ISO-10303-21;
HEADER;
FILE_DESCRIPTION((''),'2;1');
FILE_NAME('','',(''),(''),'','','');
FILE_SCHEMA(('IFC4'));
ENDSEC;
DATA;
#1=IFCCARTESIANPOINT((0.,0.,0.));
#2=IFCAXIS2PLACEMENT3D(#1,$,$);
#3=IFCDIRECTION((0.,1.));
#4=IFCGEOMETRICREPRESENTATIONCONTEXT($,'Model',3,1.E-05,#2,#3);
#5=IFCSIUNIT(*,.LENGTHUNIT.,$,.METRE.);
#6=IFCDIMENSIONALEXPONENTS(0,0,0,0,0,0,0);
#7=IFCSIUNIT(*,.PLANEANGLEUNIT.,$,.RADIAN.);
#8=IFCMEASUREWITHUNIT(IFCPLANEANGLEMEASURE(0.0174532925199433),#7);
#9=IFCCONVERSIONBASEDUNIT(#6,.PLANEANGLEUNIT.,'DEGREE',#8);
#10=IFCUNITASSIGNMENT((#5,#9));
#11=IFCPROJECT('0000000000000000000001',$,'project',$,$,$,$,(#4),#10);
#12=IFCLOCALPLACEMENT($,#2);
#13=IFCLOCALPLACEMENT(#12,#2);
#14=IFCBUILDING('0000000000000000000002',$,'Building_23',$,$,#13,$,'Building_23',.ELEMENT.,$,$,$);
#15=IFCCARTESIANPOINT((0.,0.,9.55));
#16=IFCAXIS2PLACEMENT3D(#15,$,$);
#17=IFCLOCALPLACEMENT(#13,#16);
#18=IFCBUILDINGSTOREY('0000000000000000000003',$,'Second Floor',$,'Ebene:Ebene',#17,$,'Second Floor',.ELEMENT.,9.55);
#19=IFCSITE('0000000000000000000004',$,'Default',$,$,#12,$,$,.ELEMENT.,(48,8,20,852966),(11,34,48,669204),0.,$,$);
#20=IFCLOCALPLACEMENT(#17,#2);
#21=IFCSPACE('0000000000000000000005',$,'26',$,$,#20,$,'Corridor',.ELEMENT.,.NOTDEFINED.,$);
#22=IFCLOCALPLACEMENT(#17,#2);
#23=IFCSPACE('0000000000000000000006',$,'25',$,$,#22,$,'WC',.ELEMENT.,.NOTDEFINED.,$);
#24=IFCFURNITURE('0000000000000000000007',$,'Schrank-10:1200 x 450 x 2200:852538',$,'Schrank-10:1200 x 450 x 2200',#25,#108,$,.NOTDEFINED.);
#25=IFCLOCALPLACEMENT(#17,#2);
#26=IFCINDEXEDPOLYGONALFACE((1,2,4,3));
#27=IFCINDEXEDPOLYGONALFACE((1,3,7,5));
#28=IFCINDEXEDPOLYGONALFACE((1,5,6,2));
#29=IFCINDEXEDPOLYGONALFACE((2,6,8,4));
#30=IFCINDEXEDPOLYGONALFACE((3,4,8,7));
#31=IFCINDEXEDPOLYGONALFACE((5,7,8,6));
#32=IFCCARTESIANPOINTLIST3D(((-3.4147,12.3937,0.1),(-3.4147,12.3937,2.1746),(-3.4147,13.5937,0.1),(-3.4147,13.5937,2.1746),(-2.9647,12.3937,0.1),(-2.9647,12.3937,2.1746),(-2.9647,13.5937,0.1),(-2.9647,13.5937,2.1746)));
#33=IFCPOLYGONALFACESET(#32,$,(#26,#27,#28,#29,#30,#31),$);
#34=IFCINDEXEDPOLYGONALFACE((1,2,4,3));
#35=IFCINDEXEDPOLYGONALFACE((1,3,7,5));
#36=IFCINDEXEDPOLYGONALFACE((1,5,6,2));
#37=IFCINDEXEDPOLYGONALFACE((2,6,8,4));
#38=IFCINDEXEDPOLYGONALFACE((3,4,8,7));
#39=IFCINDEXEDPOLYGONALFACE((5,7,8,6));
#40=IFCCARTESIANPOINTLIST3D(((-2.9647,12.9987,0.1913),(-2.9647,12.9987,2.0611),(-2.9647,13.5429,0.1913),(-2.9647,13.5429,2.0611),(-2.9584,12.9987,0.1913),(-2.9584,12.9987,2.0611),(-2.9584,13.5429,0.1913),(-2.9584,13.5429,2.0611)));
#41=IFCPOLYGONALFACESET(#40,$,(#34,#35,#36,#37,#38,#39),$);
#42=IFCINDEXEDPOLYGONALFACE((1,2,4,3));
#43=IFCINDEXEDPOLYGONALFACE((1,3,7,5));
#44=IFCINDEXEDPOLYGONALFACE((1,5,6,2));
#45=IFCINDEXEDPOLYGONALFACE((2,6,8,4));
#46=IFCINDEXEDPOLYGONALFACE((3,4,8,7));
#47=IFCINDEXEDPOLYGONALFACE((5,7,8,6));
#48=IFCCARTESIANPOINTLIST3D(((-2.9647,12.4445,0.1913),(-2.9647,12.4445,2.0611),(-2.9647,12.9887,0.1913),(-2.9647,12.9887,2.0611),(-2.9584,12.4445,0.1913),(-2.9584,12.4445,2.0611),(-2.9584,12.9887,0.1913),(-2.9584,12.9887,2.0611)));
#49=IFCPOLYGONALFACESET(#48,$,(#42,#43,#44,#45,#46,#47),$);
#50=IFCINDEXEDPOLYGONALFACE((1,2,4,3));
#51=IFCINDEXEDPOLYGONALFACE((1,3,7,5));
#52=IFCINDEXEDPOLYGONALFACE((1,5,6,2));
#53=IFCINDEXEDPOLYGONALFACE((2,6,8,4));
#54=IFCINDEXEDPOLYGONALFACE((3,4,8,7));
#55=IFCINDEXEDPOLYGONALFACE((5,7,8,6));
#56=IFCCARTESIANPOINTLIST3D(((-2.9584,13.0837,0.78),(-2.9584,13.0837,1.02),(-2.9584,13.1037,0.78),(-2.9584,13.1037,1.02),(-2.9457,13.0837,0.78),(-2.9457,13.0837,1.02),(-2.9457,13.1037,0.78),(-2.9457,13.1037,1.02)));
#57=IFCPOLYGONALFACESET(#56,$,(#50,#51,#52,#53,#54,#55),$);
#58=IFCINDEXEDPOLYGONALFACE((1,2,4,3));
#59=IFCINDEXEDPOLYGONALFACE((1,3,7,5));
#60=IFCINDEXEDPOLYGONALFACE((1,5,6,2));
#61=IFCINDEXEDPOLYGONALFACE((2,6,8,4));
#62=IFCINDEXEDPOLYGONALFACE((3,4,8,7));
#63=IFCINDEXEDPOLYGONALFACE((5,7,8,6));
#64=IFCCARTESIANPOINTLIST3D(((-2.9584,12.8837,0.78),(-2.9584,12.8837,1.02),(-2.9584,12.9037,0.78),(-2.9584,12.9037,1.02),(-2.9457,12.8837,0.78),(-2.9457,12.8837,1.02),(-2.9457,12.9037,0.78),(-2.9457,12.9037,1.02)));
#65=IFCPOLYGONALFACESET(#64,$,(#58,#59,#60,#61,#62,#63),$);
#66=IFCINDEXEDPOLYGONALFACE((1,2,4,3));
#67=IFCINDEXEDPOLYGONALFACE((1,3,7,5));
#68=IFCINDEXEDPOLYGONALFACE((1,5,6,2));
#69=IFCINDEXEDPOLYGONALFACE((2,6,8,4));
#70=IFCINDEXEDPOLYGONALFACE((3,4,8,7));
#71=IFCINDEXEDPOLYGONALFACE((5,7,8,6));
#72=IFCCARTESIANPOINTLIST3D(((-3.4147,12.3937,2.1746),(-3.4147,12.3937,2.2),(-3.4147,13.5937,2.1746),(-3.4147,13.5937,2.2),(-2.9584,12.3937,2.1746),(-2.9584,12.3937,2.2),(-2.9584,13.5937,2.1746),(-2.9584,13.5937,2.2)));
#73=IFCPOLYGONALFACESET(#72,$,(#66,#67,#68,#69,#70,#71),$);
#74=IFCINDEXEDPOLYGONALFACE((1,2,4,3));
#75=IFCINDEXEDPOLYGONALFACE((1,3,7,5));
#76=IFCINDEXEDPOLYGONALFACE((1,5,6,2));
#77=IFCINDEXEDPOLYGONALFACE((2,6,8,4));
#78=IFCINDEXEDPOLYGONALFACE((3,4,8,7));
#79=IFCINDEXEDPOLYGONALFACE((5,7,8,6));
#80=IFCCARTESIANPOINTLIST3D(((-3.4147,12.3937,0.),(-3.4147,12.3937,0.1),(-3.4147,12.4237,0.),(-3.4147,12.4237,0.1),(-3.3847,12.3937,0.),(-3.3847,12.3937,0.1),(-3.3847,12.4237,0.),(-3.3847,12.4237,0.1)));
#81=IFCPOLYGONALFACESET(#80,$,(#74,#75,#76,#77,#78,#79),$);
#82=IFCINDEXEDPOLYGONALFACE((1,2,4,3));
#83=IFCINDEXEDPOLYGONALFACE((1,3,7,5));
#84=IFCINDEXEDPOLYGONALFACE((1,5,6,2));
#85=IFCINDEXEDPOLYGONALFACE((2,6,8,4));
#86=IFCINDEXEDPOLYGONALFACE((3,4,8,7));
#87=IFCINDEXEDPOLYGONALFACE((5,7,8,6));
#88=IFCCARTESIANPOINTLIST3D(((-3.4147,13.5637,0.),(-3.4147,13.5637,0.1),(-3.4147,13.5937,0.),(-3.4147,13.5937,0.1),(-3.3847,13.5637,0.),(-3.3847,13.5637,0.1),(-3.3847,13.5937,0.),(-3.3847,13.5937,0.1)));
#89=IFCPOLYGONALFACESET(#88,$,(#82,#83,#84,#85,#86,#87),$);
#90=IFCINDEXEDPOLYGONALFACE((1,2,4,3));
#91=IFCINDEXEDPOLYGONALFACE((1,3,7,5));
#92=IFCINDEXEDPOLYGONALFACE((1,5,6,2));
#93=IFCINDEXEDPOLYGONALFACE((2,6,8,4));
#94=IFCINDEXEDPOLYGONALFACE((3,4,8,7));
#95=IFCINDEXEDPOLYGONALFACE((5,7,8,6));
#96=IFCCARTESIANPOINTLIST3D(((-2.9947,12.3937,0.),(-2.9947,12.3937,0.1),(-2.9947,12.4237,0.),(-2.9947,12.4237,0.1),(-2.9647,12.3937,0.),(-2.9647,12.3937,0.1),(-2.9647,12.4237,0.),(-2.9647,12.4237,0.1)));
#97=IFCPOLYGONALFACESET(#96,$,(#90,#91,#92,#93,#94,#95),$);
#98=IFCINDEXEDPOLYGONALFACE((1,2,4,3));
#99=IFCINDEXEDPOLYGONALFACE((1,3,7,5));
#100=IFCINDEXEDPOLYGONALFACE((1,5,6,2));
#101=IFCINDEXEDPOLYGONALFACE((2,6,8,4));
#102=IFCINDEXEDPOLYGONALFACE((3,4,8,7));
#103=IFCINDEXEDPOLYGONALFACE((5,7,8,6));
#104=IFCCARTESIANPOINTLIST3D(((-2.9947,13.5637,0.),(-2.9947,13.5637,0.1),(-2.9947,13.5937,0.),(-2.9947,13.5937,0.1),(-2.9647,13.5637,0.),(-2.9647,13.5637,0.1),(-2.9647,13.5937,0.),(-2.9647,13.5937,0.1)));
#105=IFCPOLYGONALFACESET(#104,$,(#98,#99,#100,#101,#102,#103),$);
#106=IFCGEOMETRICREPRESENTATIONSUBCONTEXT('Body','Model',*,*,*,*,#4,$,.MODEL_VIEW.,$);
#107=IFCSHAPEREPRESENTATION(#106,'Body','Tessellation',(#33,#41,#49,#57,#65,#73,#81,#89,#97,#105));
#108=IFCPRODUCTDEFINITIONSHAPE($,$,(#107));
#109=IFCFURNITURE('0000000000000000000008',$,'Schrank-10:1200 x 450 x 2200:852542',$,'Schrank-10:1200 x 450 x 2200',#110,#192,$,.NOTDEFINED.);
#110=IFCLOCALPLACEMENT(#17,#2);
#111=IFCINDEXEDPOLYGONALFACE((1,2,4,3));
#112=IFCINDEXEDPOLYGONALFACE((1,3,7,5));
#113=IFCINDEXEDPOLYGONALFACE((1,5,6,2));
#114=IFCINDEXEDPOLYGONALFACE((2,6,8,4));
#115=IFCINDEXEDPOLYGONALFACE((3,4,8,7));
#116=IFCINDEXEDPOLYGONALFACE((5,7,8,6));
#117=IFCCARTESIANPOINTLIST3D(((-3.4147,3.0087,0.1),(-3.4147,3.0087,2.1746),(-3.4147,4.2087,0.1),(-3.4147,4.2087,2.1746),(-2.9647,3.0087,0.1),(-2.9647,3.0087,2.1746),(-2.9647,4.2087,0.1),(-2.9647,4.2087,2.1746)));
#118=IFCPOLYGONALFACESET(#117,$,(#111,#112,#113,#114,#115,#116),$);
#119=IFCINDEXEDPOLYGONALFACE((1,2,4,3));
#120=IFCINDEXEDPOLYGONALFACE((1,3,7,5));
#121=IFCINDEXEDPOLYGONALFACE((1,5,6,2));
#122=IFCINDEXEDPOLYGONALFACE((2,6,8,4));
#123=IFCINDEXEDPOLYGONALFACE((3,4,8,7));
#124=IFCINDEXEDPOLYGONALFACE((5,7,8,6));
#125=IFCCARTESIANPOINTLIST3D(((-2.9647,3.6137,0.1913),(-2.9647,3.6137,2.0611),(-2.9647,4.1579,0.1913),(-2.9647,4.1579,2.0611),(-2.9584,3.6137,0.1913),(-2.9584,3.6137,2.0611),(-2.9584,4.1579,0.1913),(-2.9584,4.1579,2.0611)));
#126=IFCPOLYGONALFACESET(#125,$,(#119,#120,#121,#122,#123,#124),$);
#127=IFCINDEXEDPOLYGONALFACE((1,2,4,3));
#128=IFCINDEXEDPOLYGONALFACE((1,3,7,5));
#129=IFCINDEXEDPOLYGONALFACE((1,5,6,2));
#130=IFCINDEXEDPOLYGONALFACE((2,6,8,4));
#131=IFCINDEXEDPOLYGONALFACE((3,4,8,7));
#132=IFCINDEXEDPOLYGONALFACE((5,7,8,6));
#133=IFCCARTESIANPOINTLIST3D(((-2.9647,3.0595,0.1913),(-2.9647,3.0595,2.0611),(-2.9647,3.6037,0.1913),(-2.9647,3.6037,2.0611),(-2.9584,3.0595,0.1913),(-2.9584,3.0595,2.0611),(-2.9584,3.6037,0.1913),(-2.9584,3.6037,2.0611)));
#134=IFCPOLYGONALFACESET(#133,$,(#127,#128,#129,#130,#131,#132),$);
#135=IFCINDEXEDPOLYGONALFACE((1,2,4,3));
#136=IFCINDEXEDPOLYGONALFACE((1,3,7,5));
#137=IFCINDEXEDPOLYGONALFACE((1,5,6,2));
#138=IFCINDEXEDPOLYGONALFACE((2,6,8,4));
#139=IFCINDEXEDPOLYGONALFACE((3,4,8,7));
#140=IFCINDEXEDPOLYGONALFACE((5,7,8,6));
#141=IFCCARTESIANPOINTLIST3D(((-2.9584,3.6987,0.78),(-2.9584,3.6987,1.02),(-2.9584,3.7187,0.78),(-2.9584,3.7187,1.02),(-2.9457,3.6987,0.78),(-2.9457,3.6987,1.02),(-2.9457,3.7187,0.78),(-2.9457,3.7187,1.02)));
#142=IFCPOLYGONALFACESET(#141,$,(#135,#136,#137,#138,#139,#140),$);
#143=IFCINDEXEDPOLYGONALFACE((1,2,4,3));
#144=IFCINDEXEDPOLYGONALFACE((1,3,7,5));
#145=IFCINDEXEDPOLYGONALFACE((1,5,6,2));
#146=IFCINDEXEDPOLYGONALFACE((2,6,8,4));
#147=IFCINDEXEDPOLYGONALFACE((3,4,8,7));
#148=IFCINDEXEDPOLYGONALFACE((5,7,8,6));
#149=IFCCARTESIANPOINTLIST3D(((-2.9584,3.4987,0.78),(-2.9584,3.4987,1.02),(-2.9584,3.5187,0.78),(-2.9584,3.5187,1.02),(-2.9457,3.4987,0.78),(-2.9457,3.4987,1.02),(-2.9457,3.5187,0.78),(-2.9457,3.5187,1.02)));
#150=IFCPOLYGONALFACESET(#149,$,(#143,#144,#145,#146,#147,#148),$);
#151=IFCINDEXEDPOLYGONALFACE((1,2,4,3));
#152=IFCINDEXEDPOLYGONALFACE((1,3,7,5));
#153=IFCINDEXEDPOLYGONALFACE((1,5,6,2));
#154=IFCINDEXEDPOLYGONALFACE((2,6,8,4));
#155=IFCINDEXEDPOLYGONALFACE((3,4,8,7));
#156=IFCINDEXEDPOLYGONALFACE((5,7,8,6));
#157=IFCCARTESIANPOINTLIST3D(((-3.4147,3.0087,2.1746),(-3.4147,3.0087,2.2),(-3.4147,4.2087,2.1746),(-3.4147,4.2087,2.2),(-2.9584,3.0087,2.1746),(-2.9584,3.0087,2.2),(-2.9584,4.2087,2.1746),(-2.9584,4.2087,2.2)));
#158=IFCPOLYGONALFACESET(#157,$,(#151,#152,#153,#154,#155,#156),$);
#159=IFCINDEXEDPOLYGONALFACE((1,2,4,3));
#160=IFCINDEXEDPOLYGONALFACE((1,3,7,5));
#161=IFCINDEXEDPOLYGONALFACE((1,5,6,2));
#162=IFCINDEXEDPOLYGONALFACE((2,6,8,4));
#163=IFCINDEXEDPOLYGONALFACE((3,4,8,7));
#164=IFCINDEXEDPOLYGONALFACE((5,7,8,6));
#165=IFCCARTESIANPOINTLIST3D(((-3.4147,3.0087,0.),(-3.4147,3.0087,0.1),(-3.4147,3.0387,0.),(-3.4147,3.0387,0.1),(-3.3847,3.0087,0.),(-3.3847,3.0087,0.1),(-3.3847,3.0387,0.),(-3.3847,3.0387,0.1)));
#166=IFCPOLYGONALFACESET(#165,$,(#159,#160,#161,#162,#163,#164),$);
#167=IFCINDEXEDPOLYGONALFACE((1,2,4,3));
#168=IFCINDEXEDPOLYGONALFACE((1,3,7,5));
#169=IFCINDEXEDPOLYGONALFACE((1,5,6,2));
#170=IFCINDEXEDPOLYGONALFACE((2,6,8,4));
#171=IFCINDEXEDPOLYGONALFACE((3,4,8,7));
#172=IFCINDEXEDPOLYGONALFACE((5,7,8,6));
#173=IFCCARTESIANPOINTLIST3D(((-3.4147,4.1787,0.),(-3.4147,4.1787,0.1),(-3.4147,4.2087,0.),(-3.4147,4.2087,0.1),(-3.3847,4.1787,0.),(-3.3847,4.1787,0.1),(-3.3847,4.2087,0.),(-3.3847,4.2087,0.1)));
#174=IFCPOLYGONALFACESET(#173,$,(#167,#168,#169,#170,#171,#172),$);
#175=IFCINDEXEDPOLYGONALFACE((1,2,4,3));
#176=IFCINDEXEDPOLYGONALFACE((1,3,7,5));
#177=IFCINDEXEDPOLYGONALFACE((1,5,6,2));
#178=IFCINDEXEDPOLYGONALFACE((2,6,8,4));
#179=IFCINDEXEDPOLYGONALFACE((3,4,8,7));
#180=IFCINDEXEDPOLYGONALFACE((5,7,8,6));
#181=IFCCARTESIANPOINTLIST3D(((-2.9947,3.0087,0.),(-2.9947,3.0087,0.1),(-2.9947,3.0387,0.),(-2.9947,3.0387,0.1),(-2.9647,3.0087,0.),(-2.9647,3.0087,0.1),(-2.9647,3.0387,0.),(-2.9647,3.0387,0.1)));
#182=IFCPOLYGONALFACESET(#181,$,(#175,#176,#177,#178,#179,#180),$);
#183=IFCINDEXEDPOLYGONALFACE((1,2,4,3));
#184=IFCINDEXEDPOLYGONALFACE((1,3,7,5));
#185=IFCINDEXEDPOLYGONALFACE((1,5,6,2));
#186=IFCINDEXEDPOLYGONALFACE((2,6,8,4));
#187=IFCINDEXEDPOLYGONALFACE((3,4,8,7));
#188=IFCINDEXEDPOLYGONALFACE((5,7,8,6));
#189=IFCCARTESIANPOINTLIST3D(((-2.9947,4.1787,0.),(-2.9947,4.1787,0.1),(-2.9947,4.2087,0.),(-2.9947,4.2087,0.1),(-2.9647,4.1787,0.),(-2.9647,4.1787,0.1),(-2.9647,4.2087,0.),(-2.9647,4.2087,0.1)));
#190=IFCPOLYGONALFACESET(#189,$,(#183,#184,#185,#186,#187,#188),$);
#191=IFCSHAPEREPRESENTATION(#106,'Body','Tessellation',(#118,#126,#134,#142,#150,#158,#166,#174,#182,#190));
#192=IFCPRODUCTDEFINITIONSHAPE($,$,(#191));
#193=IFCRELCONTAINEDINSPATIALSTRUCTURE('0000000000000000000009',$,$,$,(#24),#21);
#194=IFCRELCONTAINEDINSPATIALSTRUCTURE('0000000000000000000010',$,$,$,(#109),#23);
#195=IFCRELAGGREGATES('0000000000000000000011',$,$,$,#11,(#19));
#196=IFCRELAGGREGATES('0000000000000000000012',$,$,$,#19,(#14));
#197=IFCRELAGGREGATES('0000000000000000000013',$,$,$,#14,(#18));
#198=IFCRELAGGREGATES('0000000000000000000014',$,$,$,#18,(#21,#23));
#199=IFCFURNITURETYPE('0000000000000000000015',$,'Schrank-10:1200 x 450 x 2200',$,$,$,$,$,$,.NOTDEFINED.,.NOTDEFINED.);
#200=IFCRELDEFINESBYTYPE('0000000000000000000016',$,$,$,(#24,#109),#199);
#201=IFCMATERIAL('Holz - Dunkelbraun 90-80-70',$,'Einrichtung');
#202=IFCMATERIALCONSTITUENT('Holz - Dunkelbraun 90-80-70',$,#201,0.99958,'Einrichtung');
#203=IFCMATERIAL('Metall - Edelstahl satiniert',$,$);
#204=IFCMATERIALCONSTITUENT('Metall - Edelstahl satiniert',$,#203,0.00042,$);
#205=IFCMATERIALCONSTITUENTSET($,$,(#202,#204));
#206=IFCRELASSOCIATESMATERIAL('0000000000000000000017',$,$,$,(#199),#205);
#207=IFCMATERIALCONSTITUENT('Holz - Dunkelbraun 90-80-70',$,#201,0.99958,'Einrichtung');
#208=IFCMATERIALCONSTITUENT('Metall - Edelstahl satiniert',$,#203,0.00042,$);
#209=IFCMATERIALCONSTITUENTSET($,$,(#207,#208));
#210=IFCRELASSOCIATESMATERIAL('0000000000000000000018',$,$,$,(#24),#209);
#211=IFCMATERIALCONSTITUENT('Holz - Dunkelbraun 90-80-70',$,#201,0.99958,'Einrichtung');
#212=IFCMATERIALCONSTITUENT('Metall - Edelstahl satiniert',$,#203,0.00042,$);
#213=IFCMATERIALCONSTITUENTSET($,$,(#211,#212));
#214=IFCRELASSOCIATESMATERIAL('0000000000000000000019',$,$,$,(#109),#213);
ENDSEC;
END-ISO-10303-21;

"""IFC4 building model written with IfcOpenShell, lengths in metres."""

from ifc_helpers import new_model, entity, si_unit, converted_unit, direction, frame, origin, place, context, subcontext, project, spatial, indexed_curve, outline, extrude, source, transform, mapped, material, constituent, constituent_set, type_object, type_shapes, element, save


model = new_model("IFC4")

# Units and contexts
model_context = context("Model", 3, precision=1e-05, world=origin(), true_north=direction((0.0, 1.0)))
body_context = subcontext(model_context, "Body", "Model", "MODEL_VIEW")
ifc_project = project(units=[si_unit("LENGTHUNIT", "METRE"), converted_unit("PLANEANGLEUNIT", "DEGREE", entity("IfcPlaneAngleMeasure", 0.0174532925199433), si_unit("PLANEANGLEUNIT", "RADIAN"), dimensions=[0, 0, 0, 0, 0, 0, 0])], contexts=[model_context])

# Site, building, storey
site_placement = place(None, origin())
site = spatial("IfcSite", under=ifc_project, at=site_placement, Name="Default", CompositionType="ELEMENT", RefLatitude=(48, 8, 20, 852966), RefLongitude=(11, 34, 48, 669204), RefElevation=0.0)
building_placement = place(site_placement, origin())
building = spatial("IfcBuilding", under=site, at=building_placement, Name="Building_23", LongName="Building_23", CompositionType="ELEMENT")
storey_placement = place(building_placement, frame((0.0, 0.0, 9.55)))
storey = spatial("IfcBuildingStorey", under=building, at=storey_placement, Name="Second Floor", ObjectType="Ebene:Ebene", LongName="Second Floor", CompositionType="ELEMENT", Elevation=9.55)

# Shared definitions
ifc_material_1 = material(Name="Holz - Dunkelbraun 90-80-70", Category="Einrichtung")
ifc_material_2 = material(Name="Metall - Edelstahl satiniert")

# Shared definitions
space_1_placement = place(storey_placement, origin())
space_1 = spatial("IfcSpace", under=storey, at=space_1_placement, Name="26", LongName="Corridor", CompositionType="ELEMENT", PredefinedType="NOTDEFINED")

# Furniture
ifc_constituent_1 = constituent(ifc_material_1, Name="Holz - Dunkelbraun 90-80-70", Category="Einrichtung", fraction=0.99958)
ifc_constituent_2 = constituent(ifc_material_2, Name="Metall - Edelstahl satiniert", fraction=0.00042)
ifc_constituent_set_1 = constituent_set(constituents=[ifc_constituent_1, ifc_constituent_2])
ifc_constituent_3 = constituent(ifc_material_1, Name="Holz - Dunkelbraun 90-80-70", Category="Einrichtung", fraction=0.99958)
ifc_constituent_4 = constituent(ifc_material_2, Name="Metall - Edelstahl satiniert", fraction=0.00042)
ifc_constituent_set_2 = constituent_set(constituents=[ifc_constituent_3, ifc_constituent_4])
furniture_type_1 = type_object("IfcFurnitureType", Name="Schrank-10:1200 x 450 x 2200", AssemblyPlace="NOTDEFINED", PredefinedType="NOTDEFINED", material=ifc_constituent_set_2)
shared_shape_1 = source(origin(), body_context, "Body", "SweptSolid", [
    extrude(outline(indexed_curve([(-0.225, -0.6), (0.225, -0.6), (0.225, 0.6), (-0.225, 0.6), (-0.225, -0.6)], self_intersect=False)), frame((-0.2692, -0.3632, 0.1), z_axis=(0.0, 0.0, 1.0), x_axis=(0.0, 1.0, 0.0)), (0.0, 0.0, 1.0), 2.0746),
    extrude(outline(indexed_curve([(-0.0032, -0.2721), (0.0032, -0.2721), (0.0032, 0.2721), (-0.0032, 0.2721), (-0.0032, -0.2721)], self_intersect=False)), frame((0.0079, -0.5913, 0.1913), z_axis=(0.0, 0.0, 1.0), x_axis=(0.0, 1.0, 0.0)), (0.0, 0.0, 1.0), 1.8698),
    extrude(outline(indexed_curve([(-0.0032, -0.2721), (0.0032, -0.2721), (0.0032, 0.2721), (-0.0032, 0.2721), (-0.0032, -0.2721)], self_intersect=False)), frame((-0.5463, -0.5913, 0.1913), z_axis=(0.0, 0.0, 1.0), x_axis=(0.0, 1.0, 0.0)), (0.0, 0.0, 1.0), 1.8698),
    extrude(outline(indexed_curve([(-0.0063, -0.01), (0.0063, -0.01), (0.0063, 0.01), (-0.0063, 0.01), (-0.0063, -0.01)], self_intersect=False)), frame((-0.1692, -0.6009, 0.78), z_axis=(0.0, 0.0, 1.0), x_axis=(0.0, 1.0, 0.0)), (0.0, 0.0, 1.0), 0.24),
    extrude(outline(indexed_curve([(-0.0063, -0.01), (0.0063, -0.01), (0.0063, 0.01), (-0.0063, 0.01), (-0.0063, -0.01)], self_intersect=False)), frame((-0.3692, -0.6009, 0.78), z_axis=(0.0, 0.0, 1.0), x_axis=(0.0, 1.0, 0.0)), (0.0, 0.0, 1.0), 0.24),
    extrude(outline(indexed_curve([(-0.6, -0.2282), (0.6, -0.2282), (0.6, 0.2282), (-0.6, 0.2282), (-0.6, -0.2282)], self_intersect=False)), frame((-0.2692, -0.3663, 2.1746), z_axis=(0.0, 0.0, 1.0), x_axis=(-1.0, 0.0, 0.0)), (0.0, 0.0, 1.0), 0.0254),
    extrude(outline(indexed_curve([(-0.015, -0.015), (0.015, -0.015), (0.015, 0.015), (-0.015, 0.015), (-0.015, -0.015)], self_intersect=False)), frame((-0.8542, -0.1532, 0.0), z_axis=(0.0, 0.0, 1.0), x_axis=(-1.0, 0.0, 0.0)), (0.0, 0.0, 1.0), 0.1),
    extrude(outline(indexed_curve([(-0.015, -0.015), (0.015, -0.015), (0.015, 0.015), (-0.015, 0.015), (-0.015, -0.015)], self_intersect=False)), frame((0.3158, -0.1532, 0.0), z_axis=(0.0, 0.0, 1.0), x_axis=(0.0, -1.0, 0.0)), (0.0, 0.0, 1.0), 0.1),
    extrude(outline(indexed_curve([(-0.015, -0.015), (0.015, -0.015), (0.015, 0.015), (-0.015, 0.015), (-0.015, -0.015)], self_intersect=False)), frame((-0.8542, -0.5732, 0.0), z_axis=(0.0, 0.0, 1.0), x_axis=(0.0, 1.0, 0.0)), (0.0, 0.0, 1.0), 0.1),
    extrude(outline(indexed_curve([(-0.015, -0.015), (0.015, -0.015), (0.015, 0.015), (-0.015, 0.015), (-0.015, -0.015)], self_intersect=False)), frame((0.3158, -0.5732, 0.0)), (0.0, 0.0, 1.0), 0.1),
])
type_shapes(furniture_type_1, [shared_shape_1])
furniture_1_placement = place(space_1_placement, frame((-3.5529, 13.2629, 0.0), z_axis=(0.0, 0.0, 1.0), x_axis=(0.0, 1.0, 0.0)))
element("IfcFurniture", 1, at=furniture_1_placement, inside=space_1, type_object=furniture_type_1, material=ifc_constituent_set_1, Name="Schrank-10:1200 x 450 x 2200:852538", ObjectType="Schrank-10:1200 x 450 x 2200", PredefinedType="NOTDEFINED", context=body_context, shape_type="MappedRepresentation", body=[
    mapped(shared_shape_1, transform((0.0, 0.0, 0.0), scale=1.0)),
])

# Shared definitions
space_2_placement = place(storey_placement, origin())
space_2 = spatial("IfcSpace", under=storey, at=space_2_placement, Name="25", LongName="WC", CompositionType="ELEMENT", PredefinedType="NOTDEFINED")

# Furniture
ifc_constituent_5 = constituent(ifc_material_1, Name="Holz - Dunkelbraun 90-80-70", Category="Einrichtung", fraction=0.99958)
ifc_constituent_6 = constituent(ifc_material_2, Name="Metall - Edelstahl satiniert", fraction=0.00042)
ifc_constituent_set_3 = constituent_set(constituents=[ifc_constituent_5, ifc_constituent_6])
furniture_2_placement = place(space_2_placement, frame((-3.5529, 3.8779, 0.0), z_axis=(0.0, 0.0, 1.0), x_axis=(0.0, 1.0, 0.0)))
element("IfcFurniture", 2, at=furniture_2_placement, inside=space_2, type_object=furniture_type_1, material=ifc_constituent_set_3, Name="Schrank-10:1200 x 450 x 2200:852542", ObjectType="Schrank-10:1200 x 450 x 2200", PredefinedType="NOTDEFINED", context=body_context, shape_type="MappedRepresentation", body=[
    mapped(shared_shape_1, transform((0.0, 0.0, 0.0), scale=1.0)),
])

save(model, "model.ifc")
